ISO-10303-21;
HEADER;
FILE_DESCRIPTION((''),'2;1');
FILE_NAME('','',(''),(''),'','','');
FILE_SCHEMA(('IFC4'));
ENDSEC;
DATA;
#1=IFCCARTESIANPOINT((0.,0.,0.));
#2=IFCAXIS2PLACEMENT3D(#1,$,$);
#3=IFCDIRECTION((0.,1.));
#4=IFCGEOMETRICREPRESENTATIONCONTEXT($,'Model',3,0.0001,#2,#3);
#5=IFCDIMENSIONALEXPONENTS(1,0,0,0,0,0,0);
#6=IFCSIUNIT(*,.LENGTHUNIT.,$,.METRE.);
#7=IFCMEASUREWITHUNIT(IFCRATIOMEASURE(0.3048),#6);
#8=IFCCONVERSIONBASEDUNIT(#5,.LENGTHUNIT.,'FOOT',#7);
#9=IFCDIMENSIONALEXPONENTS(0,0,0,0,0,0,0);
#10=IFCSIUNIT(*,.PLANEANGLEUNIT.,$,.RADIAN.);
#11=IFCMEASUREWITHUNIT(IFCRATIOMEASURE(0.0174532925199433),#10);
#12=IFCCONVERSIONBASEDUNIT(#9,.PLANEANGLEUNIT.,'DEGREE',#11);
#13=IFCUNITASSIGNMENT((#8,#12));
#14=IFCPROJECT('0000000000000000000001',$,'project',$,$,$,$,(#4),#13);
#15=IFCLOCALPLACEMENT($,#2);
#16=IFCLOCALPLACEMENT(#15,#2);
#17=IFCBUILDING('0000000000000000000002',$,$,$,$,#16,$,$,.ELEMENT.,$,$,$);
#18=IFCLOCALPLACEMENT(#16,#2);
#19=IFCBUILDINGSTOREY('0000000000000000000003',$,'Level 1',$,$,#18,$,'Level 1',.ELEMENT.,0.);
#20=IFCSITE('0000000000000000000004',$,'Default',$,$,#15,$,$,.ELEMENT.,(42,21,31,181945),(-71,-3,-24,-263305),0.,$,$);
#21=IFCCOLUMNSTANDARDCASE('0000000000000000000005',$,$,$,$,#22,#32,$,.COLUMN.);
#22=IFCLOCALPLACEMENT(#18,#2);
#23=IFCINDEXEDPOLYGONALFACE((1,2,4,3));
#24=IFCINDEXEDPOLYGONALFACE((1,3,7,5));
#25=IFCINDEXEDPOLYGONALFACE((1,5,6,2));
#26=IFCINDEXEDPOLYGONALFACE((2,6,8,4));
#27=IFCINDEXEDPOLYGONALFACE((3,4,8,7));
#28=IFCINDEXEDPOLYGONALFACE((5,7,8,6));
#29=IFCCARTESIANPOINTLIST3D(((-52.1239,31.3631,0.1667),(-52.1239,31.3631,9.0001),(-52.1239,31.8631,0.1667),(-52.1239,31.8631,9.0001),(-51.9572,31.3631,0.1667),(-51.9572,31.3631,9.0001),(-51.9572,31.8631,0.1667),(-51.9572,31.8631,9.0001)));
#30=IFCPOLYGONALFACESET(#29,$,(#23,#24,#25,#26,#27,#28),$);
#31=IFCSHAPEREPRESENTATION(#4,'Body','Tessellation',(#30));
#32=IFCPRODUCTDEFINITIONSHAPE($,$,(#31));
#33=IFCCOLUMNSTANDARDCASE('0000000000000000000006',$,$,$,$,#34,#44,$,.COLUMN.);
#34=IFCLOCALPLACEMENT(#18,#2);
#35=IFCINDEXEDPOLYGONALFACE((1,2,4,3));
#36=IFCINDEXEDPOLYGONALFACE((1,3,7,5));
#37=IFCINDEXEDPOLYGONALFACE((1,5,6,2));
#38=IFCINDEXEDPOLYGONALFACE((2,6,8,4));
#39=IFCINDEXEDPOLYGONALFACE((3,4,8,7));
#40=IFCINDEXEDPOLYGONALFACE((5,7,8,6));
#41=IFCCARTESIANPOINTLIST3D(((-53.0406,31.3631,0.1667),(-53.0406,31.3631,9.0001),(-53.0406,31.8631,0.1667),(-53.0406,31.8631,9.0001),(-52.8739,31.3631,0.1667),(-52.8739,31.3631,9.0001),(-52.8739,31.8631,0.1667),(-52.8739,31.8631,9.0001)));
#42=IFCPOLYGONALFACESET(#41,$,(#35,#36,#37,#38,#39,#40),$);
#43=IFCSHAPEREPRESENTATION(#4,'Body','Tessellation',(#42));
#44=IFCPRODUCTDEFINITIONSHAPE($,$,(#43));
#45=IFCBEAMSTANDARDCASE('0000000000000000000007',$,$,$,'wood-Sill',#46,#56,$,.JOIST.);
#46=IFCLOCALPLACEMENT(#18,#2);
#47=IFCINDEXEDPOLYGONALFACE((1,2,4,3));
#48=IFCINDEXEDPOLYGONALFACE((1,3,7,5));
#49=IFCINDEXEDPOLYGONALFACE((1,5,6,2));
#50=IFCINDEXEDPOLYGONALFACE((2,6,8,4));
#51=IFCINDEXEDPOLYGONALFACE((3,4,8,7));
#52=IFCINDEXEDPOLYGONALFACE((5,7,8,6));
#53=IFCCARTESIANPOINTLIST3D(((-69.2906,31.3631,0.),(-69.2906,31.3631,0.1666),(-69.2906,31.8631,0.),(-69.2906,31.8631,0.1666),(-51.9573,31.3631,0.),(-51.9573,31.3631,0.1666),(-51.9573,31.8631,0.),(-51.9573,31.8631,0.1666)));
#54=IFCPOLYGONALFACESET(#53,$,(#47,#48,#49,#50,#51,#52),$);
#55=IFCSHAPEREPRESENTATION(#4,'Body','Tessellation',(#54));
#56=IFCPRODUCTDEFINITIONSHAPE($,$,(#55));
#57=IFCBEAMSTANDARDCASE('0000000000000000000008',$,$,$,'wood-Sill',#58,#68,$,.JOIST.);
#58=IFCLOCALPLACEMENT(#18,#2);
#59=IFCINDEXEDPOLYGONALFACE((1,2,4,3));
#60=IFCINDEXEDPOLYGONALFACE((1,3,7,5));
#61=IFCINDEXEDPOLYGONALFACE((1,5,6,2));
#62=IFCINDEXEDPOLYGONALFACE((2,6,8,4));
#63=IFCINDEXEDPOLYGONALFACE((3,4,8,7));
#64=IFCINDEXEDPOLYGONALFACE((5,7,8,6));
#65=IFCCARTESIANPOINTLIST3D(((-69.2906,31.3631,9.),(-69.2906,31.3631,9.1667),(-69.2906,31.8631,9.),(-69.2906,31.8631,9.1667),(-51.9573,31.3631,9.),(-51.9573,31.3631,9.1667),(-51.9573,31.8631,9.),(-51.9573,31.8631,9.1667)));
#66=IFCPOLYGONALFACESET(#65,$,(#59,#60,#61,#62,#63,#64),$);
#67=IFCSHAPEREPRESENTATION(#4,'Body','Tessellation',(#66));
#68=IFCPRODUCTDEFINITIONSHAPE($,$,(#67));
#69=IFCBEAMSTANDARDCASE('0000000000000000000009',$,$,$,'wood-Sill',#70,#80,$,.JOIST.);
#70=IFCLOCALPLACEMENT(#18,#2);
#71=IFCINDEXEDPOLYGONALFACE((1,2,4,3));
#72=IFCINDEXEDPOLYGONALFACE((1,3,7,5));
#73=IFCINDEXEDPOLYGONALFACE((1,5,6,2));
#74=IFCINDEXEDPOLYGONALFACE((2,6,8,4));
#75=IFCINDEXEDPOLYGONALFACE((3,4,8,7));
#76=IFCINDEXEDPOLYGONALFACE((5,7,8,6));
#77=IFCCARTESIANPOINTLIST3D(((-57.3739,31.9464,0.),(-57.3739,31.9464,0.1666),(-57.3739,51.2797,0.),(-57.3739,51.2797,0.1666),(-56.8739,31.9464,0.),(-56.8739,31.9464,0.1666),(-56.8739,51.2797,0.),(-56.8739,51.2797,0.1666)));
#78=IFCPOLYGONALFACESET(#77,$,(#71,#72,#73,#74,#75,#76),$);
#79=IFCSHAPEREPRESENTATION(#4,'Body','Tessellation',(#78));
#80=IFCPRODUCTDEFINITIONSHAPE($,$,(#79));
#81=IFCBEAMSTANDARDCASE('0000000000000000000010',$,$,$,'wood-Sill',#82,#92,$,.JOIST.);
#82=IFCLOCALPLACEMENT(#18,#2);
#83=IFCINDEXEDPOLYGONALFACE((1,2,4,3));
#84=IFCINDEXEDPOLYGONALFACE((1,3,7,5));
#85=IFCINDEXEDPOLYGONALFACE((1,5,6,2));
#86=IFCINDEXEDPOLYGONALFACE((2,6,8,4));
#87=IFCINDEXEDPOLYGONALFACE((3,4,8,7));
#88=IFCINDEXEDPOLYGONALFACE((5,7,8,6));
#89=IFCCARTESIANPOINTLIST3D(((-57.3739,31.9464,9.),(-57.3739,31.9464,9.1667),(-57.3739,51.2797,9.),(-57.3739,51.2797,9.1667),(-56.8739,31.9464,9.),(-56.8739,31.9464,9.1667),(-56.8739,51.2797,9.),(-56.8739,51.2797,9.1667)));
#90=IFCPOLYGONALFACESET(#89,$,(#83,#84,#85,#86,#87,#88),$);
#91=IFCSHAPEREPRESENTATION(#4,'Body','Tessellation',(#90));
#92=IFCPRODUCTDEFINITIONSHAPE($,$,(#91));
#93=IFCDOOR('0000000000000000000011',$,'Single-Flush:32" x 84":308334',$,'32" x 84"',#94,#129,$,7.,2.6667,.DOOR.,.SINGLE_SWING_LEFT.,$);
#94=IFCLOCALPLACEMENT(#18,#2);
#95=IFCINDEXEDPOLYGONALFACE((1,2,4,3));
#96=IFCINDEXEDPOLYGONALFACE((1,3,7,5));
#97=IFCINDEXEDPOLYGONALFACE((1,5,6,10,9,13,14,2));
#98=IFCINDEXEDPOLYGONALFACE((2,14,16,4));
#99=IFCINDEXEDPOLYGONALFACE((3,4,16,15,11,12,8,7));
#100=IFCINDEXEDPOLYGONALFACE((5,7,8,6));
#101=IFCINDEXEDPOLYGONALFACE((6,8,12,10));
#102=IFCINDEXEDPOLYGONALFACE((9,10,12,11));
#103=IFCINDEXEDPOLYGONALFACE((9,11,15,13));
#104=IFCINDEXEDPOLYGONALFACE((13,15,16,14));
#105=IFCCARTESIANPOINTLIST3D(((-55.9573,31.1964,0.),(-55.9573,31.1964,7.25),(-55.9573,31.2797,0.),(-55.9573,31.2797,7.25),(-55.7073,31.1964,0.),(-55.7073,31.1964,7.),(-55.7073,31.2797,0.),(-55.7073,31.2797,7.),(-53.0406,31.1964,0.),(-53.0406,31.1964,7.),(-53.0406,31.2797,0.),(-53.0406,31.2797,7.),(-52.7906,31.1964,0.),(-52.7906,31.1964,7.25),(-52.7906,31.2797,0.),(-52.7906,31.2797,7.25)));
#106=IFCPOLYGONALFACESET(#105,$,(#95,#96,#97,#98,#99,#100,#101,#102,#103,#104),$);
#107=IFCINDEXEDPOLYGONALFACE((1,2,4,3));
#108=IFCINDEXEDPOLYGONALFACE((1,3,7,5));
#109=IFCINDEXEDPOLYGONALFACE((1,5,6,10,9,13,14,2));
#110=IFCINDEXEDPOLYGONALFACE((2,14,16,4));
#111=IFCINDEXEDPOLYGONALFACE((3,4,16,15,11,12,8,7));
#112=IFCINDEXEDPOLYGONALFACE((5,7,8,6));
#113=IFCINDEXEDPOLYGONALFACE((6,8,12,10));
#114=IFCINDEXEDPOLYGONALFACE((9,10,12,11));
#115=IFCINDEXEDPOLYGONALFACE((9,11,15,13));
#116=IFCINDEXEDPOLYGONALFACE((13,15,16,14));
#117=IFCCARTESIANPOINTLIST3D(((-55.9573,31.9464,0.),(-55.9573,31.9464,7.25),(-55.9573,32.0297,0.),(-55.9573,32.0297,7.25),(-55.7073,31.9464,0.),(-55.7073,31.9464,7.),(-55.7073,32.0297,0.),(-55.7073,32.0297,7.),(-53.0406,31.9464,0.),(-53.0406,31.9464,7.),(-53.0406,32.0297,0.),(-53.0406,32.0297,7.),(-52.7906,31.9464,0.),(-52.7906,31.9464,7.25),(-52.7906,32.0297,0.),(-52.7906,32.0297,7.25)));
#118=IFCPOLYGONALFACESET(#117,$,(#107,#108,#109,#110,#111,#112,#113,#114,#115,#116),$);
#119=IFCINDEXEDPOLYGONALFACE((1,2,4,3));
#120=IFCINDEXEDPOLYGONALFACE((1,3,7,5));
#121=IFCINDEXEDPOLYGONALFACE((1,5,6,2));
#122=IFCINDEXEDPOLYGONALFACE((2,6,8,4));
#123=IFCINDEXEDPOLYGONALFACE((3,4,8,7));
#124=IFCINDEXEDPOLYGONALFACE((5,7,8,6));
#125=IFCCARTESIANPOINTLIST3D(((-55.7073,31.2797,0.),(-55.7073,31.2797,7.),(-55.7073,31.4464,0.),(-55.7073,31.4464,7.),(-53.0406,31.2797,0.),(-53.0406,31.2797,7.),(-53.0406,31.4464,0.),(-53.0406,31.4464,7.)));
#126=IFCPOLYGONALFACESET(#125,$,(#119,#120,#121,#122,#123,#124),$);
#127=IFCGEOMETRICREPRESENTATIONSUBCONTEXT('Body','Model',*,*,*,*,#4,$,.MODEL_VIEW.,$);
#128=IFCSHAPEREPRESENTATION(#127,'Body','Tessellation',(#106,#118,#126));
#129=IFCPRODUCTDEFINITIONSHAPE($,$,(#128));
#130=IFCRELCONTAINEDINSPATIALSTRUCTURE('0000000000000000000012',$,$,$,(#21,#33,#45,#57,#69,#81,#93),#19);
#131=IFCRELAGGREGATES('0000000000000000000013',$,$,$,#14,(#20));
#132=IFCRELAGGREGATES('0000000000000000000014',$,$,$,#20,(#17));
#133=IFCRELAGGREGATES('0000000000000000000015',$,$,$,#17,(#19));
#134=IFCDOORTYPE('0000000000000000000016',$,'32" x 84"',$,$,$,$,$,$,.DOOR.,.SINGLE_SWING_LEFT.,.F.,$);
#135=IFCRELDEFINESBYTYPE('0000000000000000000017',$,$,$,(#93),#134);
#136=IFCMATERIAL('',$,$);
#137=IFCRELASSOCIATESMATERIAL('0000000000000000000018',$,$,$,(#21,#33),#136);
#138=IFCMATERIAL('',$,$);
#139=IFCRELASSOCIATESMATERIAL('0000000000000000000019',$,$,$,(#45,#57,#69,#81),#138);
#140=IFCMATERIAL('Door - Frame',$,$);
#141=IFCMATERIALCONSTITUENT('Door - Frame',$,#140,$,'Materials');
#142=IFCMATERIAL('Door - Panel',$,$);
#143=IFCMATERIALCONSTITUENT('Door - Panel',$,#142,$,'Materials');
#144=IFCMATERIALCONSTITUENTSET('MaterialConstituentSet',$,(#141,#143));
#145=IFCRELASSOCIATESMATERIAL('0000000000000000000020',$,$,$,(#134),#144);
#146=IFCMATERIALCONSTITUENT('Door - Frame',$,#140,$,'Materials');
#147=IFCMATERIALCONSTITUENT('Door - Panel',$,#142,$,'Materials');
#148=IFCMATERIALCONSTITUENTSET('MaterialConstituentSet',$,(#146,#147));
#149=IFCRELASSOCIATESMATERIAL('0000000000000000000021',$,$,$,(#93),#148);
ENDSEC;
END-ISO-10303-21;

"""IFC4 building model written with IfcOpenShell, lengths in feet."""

from ifc_helpers import new_model, entity, si_unit, converted_unit, direction, frame, frame_2d, origin, origin_with_axes, place, context, subcontext, project, spatial, polyline, rectangle, outline, extrude, source, transform, mapped, material, constituent, constituent_set, type_object, type_shapes, element, save


model = new_model("IFC4")

# Units and contexts
model_context = context("Model", 3, precision=0.0001, world=origin(), true_north=direction((0.0, 1.0)))
body_context = subcontext(model_context, "Body", "Model", "MODEL_VIEW")
ifc_project = project(units=[converted_unit("LENGTHUNIT", "FOOT", entity("IfcRatioMeasure", 0.3048), si_unit("LENGTHUNIT", "METRE"), dimensions=[1, 0, 0, 0, 0, 0, 0]), converted_unit("PLANEANGLEUNIT", "DEGREE", entity("IfcRatioMeasure", 0.0174532925199433), si_unit("PLANEANGLEUNIT", "RADIAN"), dimensions=[0, 0, 0, 0, 0, 0, 0])], contexts=[model_context])

# Site, building, storey
site_placement = place(None, origin())
site = spatial("IfcSite", under=ifc_project, at=site_placement, Name="Default", CompositionType="ELEMENT", RefLatitude=(42, 21, 31, 181945), RefLongitude=(-71, -3, -24, -263305), RefElevation=0.0)
building_placement = place(site_placement, origin())
building = spatial("IfcBuilding", under=site, at=building_placement, CompositionType="ELEMENT")
storey_placement = place(building_placement, origin())
storey = spatial("IfcBuildingStorey", under=building, at=storey_placement, Name="Level 1", LongName="Level 1", CompositionType="ELEMENT", Elevation=0.0)

# Columns
ifc_material_1 = material(Name="")
placement_1 = place(storey_placement, frame((-51.9573, 31.6131, 0.0), z_axis=(0.0, 0.0, 1.0), x_axis=(-1.0, 0.0, 0.0)))
for number, where, z_axis, x_axis in (
    (1, (0.0833, 0.0, 0.1667), (0.0, 0.0, 1.0), (1.0, 0.0, 0.0)),
    (2, (1.0, 0.0, 0.1667), (0.0, 0.0, 1.0), (1.0, 0.0, 0.0)),
):
    element("IfcColumnStandardCase", number, at=place(placement_1, frame(where, z_axis=z_axis, x_axis=x_axis)), inside=storey, material=ifc_material_1, PredefinedType="COLUMN", context=model_context, shape_type="SweptSolid", body=[
        extrude(rectangle(XDim=0.1667, YDim=0.5), origin(), (0.0, 0.0, 1.0), 8.8334),
    ])

# Beams
ifc_material_2 = material(Name="")
for number, where, z_axis, x_axis in (
    (3, (0.0, 0.0, 0.0833), (1.0, 0.0, 0.0), (0.0, 0.0, 1.0)),
    (4, (0.0, 0.0, 9.0834), (1.0, 0.0, 0.0), (0.0, 0.0, 1.0)),
):
    element("IfcBeamStandardCase", number, at=place(placement_1, frame(where, z_axis=z_axis, x_axis=x_axis)), inside=storey, material=ifc_material_2, ObjectType="wood-Sill", PredefinedType="JOIST", context=model_context, shape_type="SweptSolid", body=[
        extrude(rectangle(XDim=0.1667, YDim=0.5), origin_with_axes(), (0.0, 0.0, 1.0), 17.3333),
    ])
placement_2 = place(storey_placement, frame((-57.1239, 31.9464, 0.0), z_axis=(0.0, 0.0, 1.0), x_axis=(0.0, 1.0, 0.0)))
for number, where, z_axis, x_axis in (
    (5, (0.0, 0.0, 0.0833), (1.0, 0.0, 0.0), (0.0, 0.0, 1.0)),
    (6, (0.0, 0.0, 9.0834), (1.0, 0.0, 0.0), (0.0, 0.0, 1.0)),
):
    element("IfcBeamStandardCase", number, at=place(placement_2, frame(where, z_axis=z_axis, x_axis=x_axis)), inside=storey, material=ifc_material_2, ObjectType="wood-Sill", PredefinedType="JOIST", context=model_context, shape_type="SweptSolid", body=[
        extrude(rectangle(XDim=0.1667, YDim=0.5), origin_with_axes(), (0.0, 0.0, 1.0), 19.3333),
    ])

# Door
ifc_material_3 = material(Name="Door - Frame")
ifc_constituent_1 = constituent(ifc_material_3, Name="Door - Frame", Category="Materials")
ifc_material_4 = material(Name="Door - Panel")
ifc_constituent_2 = constituent(ifc_material_4, Name="Door - Panel", Category="Materials")
ifc_constituent_set_1 = constituent_set(constituents=[ifc_constituent_1, ifc_constituent_2], Name="MaterialConstituentSet")
ifc_constituent_3 = constituent(ifc_material_3, Name="Door - Frame", Category="Materials")
ifc_constituent_4 = constituent(ifc_material_4, Name="Door - Panel", Category="Materials")
ifc_constituent_set_2 = constituent_set(constituents=[ifc_constituent_3, ifc_constituent_4], Name="MaterialConstituentSet")
door_type = type_object("IfcDoorType", Name="32\" x 84\"", OperationType="SINGLE_SWING_LEFT", ParameterTakesPrecedence=False, PredefinedType="DOOR", material=ifc_constituent_set_2)
shared_shape = source(origin(), body_context, "Body", "SweptSolid", [
    extrude(outline(polyline([(-1.5833, -3.6875), (1.5833, -3.6875), (1.5833, 3.5625), (1.3333, 3.5625), (1.3333, -3.4375), (-1.3333, -3.4375), (-1.3333, 3.5625), (-1.5833, 3.5625), (-1.5833, -3.6875)])), frame((1.3333, 0.75, 3.5625), z_axis=(0.0, -1.0, 0.0), x_axis=(-1.0, 0.0, 0.0)), (0.0, 0.0, 1.0), 0.0833),
    extrude(outline(polyline([(-3.6875, -1.5833), (3.5625, -1.5833), (3.5625, -1.3333), (-3.4375, -1.3333), (-3.4375, 1.3333), (3.5625, 1.3333), (3.5625, 1.5833), (-3.6875, 1.5833), (-3.6875, -1.5833)])), frame((1.3333, 0.0, 3.5625), z_axis=(0.0, -1.0, 0.0), x_axis=(0.0, 0.0, -1.0)), (0.0, 0.0, 1.0), 0.0833),
    extrude(rectangle(XDim=2.6667, YDim=0.1667, at=frame_2d((0.0, 0.0), x_axis=(1.0, 0.0))), frame((1.3333, 0.5833, 0.0)), (0.0, 0.0, 1.0), 7.0),
])
type_shapes(door_type, [shared_shape])
placement_3 = place(placement_1, frame((1.0833, -0.3333, 0.0)))
door_placement = place(placement_3, origin())
element("IfcDoor", 7, at=door_placement, inside=storey, type_object=door_type, material=ifc_constituent_set_1, Name="Single-Flush:32\" x 84\":308334", ObjectType="32\" x 84\"", OperationType="SINGLE_SWING_LEFT", OverallHeight=7.0, OverallWidth=2.6667, PredefinedType="DOOR", context=body_context, shape_type="MappedRepresentation", body=[
    mapped(shared_shape, transform((0.0, 0.0, 0.0), scale=1.0)),
])

save(model, "model.ifc")
